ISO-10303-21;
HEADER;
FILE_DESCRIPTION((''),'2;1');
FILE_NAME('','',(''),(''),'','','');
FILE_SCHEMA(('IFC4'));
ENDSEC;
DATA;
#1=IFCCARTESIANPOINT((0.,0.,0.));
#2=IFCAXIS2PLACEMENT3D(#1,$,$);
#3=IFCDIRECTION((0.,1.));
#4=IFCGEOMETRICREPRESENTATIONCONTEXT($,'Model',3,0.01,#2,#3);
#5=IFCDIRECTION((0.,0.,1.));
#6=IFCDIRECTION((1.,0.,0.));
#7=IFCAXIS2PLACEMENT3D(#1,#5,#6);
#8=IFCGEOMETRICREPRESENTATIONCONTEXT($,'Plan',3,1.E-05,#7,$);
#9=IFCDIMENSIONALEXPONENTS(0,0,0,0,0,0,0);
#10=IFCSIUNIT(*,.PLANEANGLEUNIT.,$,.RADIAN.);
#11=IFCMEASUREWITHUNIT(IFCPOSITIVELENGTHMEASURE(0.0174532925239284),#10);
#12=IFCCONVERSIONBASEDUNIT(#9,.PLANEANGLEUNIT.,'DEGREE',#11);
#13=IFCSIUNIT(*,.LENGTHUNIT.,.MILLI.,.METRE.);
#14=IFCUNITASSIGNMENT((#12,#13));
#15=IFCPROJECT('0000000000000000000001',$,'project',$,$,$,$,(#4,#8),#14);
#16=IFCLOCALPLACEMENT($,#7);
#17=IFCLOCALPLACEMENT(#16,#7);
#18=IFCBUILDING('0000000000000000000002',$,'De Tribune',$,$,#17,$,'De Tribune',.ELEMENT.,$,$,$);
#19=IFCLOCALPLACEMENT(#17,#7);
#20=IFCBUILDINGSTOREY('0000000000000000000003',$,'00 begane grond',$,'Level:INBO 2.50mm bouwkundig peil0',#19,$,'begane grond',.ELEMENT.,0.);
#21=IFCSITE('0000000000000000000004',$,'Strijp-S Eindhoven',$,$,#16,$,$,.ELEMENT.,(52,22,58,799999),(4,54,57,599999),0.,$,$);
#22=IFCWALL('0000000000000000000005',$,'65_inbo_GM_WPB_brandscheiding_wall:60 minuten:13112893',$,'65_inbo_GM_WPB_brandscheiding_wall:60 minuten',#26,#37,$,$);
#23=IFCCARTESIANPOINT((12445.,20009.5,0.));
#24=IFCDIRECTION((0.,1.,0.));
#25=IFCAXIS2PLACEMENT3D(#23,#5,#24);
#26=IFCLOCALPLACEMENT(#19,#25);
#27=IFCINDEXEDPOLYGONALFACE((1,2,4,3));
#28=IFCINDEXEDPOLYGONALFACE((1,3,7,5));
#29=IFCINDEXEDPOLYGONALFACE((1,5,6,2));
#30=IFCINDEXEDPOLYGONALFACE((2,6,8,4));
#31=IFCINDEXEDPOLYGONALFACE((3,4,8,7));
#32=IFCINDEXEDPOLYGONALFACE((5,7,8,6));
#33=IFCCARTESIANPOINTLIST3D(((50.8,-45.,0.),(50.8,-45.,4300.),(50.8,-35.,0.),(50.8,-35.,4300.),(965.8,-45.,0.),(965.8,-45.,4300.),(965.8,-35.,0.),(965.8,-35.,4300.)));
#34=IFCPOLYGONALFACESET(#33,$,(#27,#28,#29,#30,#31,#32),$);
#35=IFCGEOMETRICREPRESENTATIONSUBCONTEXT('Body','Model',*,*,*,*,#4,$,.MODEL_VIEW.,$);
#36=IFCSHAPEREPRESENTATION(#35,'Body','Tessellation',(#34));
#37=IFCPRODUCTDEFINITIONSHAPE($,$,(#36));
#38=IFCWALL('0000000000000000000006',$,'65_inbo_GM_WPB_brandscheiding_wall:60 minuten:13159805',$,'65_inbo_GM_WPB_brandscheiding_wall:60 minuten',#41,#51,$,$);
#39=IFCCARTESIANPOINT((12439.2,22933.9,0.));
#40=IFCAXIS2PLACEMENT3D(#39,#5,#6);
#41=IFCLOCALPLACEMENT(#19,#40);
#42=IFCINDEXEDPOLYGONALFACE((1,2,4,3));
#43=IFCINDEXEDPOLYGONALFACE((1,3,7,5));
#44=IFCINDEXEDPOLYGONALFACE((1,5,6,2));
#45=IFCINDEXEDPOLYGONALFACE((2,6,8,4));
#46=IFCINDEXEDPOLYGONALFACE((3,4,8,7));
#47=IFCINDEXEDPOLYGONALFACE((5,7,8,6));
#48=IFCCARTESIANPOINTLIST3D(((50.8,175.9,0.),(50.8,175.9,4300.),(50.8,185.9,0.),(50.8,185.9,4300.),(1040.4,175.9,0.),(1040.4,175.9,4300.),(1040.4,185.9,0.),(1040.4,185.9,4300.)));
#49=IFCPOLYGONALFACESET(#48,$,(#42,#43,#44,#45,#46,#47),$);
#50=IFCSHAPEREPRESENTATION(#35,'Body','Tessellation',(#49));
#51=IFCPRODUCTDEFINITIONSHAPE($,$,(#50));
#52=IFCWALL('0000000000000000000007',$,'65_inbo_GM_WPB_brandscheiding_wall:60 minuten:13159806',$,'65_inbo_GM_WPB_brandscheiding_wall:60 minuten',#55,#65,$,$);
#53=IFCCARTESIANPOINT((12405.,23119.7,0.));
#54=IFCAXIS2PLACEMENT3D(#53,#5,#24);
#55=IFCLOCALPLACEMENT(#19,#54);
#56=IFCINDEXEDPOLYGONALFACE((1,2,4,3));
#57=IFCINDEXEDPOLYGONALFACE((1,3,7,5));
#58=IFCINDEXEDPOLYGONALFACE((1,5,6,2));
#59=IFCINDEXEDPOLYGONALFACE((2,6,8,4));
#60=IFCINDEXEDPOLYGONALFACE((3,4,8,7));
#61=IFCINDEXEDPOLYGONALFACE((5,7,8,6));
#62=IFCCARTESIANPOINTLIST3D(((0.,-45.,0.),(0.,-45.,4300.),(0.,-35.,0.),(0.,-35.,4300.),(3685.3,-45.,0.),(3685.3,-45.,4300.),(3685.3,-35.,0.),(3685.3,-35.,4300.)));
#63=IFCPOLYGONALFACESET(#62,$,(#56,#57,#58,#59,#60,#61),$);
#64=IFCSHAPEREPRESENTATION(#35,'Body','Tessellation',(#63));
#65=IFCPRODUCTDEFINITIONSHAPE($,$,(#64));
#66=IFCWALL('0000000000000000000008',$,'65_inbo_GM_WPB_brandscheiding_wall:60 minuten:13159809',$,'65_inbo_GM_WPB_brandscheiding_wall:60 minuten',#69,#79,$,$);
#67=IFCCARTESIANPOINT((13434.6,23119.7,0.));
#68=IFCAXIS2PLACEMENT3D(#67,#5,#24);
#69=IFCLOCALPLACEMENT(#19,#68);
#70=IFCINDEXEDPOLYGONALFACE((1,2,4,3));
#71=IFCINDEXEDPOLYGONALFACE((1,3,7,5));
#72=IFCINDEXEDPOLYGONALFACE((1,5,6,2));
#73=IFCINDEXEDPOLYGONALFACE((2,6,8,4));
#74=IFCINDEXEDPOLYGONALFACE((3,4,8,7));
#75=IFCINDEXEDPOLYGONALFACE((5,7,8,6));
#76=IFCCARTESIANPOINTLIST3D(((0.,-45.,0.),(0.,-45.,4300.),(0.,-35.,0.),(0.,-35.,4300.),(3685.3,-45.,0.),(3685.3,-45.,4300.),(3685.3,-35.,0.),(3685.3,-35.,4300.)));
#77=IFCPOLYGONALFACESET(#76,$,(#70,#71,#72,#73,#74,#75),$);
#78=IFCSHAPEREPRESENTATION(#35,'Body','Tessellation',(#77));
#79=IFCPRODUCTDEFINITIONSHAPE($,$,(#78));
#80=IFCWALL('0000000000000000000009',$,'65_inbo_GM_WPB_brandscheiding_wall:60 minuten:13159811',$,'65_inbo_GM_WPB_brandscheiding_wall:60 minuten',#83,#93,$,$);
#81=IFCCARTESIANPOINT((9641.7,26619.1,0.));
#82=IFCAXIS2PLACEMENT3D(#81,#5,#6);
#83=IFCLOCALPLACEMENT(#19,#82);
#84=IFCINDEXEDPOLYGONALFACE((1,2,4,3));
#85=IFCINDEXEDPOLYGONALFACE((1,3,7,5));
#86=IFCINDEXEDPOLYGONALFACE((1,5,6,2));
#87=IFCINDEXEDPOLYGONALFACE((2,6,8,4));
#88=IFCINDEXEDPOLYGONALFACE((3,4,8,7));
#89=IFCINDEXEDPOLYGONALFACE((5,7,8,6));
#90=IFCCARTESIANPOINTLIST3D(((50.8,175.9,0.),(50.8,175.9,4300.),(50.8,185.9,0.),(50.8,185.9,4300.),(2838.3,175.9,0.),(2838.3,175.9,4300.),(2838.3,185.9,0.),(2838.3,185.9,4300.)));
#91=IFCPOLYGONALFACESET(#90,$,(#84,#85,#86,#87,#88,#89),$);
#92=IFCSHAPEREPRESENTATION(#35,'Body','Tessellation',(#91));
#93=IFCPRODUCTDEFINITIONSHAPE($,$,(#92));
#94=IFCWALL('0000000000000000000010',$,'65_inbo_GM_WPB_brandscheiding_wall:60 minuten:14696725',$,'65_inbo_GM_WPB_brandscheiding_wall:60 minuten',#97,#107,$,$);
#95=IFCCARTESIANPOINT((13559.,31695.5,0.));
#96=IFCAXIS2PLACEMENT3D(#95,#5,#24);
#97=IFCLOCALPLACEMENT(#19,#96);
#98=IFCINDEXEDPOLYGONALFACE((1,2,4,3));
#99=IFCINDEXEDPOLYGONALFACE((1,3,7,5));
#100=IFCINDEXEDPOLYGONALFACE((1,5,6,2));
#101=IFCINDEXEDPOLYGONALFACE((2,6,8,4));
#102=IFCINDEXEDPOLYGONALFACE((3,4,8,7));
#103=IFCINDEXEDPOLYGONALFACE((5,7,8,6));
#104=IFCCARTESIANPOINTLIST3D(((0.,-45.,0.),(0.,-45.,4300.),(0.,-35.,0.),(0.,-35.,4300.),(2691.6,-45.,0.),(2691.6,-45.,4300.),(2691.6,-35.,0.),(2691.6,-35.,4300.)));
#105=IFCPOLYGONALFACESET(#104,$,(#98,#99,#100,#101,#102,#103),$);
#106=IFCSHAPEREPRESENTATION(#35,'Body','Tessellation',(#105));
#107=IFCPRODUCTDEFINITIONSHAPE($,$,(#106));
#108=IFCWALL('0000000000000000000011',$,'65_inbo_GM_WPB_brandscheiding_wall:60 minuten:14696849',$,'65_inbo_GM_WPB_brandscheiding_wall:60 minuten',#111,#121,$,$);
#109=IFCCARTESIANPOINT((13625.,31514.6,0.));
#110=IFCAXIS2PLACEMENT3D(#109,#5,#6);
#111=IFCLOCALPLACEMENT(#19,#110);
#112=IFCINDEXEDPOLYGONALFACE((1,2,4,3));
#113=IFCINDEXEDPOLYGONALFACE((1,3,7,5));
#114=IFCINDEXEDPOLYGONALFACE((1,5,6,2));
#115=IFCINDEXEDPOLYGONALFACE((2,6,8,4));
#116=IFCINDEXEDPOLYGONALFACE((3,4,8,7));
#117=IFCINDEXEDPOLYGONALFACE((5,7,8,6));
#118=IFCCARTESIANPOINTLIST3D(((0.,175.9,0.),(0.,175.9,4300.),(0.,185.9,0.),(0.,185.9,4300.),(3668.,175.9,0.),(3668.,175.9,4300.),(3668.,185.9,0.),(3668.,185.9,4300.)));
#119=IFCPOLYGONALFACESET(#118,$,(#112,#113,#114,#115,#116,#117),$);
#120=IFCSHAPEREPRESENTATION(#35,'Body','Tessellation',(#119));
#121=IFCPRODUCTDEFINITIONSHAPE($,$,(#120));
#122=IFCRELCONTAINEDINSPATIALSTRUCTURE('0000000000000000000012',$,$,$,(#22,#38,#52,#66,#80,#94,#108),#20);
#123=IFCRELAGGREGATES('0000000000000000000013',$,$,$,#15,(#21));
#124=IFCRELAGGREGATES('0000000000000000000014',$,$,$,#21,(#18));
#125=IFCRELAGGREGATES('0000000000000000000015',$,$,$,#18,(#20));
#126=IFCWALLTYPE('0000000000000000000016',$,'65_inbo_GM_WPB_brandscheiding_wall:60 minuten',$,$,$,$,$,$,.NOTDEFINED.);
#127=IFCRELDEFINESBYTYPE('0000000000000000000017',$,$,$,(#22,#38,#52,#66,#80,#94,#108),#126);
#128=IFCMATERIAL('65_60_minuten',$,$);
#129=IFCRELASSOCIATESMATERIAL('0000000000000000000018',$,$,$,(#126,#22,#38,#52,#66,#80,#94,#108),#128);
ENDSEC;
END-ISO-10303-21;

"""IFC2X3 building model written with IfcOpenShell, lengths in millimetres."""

from ifc_helpers import new_model, entity, si_unit, converted_unit, direction, frame, frame_2d, origin, origin_with_axes, origin_2d_with_axis, place, context, subcontext, project, spatial, rectangle, extrude, material, type_object, element, save


model = new_model("IFC2X3")

# Units and contexts
model_context = context("Model", 3, precision=0.01, world=origin(), true_north=direction((0.0, 1.0)))
plan_context = context("Plan", 3, precision=1e-05, world=origin_with_axes())
body_context = subcontext(model_context, "Body", "Model", "MODEL_VIEW")
ifc_project = project(units=[converted_unit("PLANEANGLEUNIT", "DEGREE", entity("IfcPositiveLengthMeasure", 0.0174532925239284), si_unit("PLANEANGLEUNIT", "RADIAN"), dimensions=[0, 0, 0, 0, 0, 0, 0]), si_unit("LENGTHUNIT", "METRE", prefix="MILLI")], contexts=[model_context, plan_context])

# Site, building, storey
site_placement = place(None, origin_with_axes())
site = spatial("IfcSite", under=ifc_project, at=site_placement, Name="Strijp-S Eindhoven", CompositionType="ELEMENT", RefLatitude=(52, 22, 58, 799999), RefLongitude=(4, 54, 57, 599999), RefElevation=0.0)
building_placement = place(site_placement, origin_with_axes())
building = spatial("IfcBuilding", under=site, at=building_placement, Name="De Tribune", LongName="De Tribune", CompositionType="ELEMENT")
storey_placement = place(building_placement, origin_with_axes())
storey = spatial("IfcBuildingStorey", under=building, at=storey_placement, Name="00 begane grond", ObjectType="Level:INBO 2.50mm bouwkundig peil0", LongName="begane grond", CompositionType="ELEMENT", Elevation=0.0)

# Shared definitions
ifc_material_1 = material(Name="65_60_minuten")

# Walls
wall_type_1 = type_object("IfcWallType", Name="65_inbo_GM_WPB_brandscheiding_wall:60 minuten", PredefinedType="NOTDEFINED", material=ifc_material_1)
wall_1_placement = place(storey_placement, frame((12445.0, 20009.5, 0.0), z_axis=(0.0, 0.0, 1.0), x_axis=(0.0, 1.0, 0.0)))
element("IfcWall", 1, at=wall_1_placement, inside=storey, type_object=wall_type_1, material=ifc_material_1, Name="65_inbo_GM_WPB_brandscheiding_wall:60 minuten:13112893", ObjectType="65_inbo_GM_WPB_brandscheiding_wall:60 minuten", context=body_context, shape_type="SweptSolid", body=[
    extrude(rectangle(XDim=915.0, YDim=10.0, at=frame_2d((0.0, 0.0), x_axis=(1.0, 0.0))), frame((508.3, -40.0, 0.0), z_axis=(0.0, 0.0, 1.0), x_axis=(-1.0, 0.0, 0.0)), (0.0, 0.0, 1.0), 4300.0),
])
wall_2_placement = place(storey_placement, frame((12439.2, 22933.9, 0.0), z_axis=(0.0, 0.0, 1.0), x_axis=(1.0, 0.0, 0.0)))
element("IfcWall", 2, at=wall_2_placement, inside=storey, type_object=wall_type_1, material=ifc_material_1, Name="65_inbo_GM_WPB_brandscheiding_wall:60 minuten:13159805", ObjectType="65_inbo_GM_WPB_brandscheiding_wall:60 minuten", context=body_context, shape_type="SweptSolid", body=[
    extrude(rectangle(XDim=989.6, YDim=10.0, at=frame_2d((0.0, 0.0), x_axis=(1.0, 0.0))), frame((545.6, 180.9, 0.0), z_axis=(0.0, 0.0, 1.0), x_axis=(-1.0, 0.0, 0.0)), (0.0, 0.0, 1.0), 4300.0),
])
for number, where, z_axis, x_axis, name in (
    (3, (12405.0, 23119.7, 0.0), (0.0, 0.0, 1.0), (0.0, 1.0, 0.0), "65_inbo_GM_WPB_brandscheiding_wall:60 minuten:13159806"),
    (4, (13434.6, 23119.7, 0.0), (0.0, 0.0, 1.0), (0.0, 1.0, 0.0), "65_inbo_GM_WPB_brandscheiding_wall:60 minuten:13159809"),
):
    element("IfcWall", number, at=place(storey_placement, frame(where, z_axis=z_axis, x_axis=x_axis)), inside=storey, type_object=wall_type_1, material=ifc_material_1, Name=name, ObjectType="65_inbo_GM_WPB_brandscheiding_wall:60 minuten", context=body_context, shape_type="SweptSolid", body=[
        extrude(rectangle(XDim=10.0, YDim=3685.3, at=origin_2d_with_axis()), frame((1842.7, -40.0, 0.0), z_axis=(0.0, 0.0, 1.0), x_axis=(0.0, -1.0, 0.0)), (0.0, 0.0, 1.0), 4300.0),
    ])
wall_3_placement = place(storey_placement, frame((9641.7, 26619.1, 0.0), z_axis=(0.0, 0.0, 1.0), x_axis=(1.0, 0.0, 0.0)))
element("IfcWall", 5, at=wall_3_placement, inside=storey, type_object=wall_type_1, material=ifc_material_1, Name="65_inbo_GM_WPB_brandscheiding_wall:60 minuten:13159811", ObjectType="65_inbo_GM_WPB_brandscheiding_wall:60 minuten", context=body_context, shape_type="SweptSolid", body=[
    extrude(rectangle(XDim=2787.5, YDim=10.0, at=frame_2d((0.0, 0.0), x_axis=(1.0, 0.0))), frame((1444.6, 180.9, 0.0), z_axis=(0.0, 0.0, 1.0), x_axis=(-1.0, 0.0, 0.0)), (0.0, 0.0, 1.0), 4300.0),
])
wall_4_placement = place(storey_placement, frame((13559.0, 31695.5, 0.0), z_axis=(0.0, 0.0, 1.0), x_axis=(0.0, 1.0, 0.0)))
element("IfcWall", 6, at=wall_4_placement, inside=storey, type_object=wall_type_1, material=ifc_material_1, Name="65_inbo_GM_WPB_brandscheiding_wall:60 minuten:14696725", ObjectType="65_inbo_GM_WPB_brandscheiding_wall:60 minuten", context=body_context, shape_type="SweptSolid", body=[
    extrude(rectangle(XDim=10.0, YDim=2691.6, at=origin_2d_with_axis()), frame((1345.8, -40.0, 0.0), z_axis=(0.0, 0.0, 1.0), x_axis=(0.0, -1.0, 0.0)), (0.0, 0.0, 1.0), 4300.0),
])
wall_5_placement = place(storey_placement, frame((13625.0, 31514.6, 0.0), z_axis=(0.0, 0.0, 1.0), x_axis=(1.0, 0.0, 0.0)))
element("IfcWall", 7, at=wall_5_placement, inside=storey, type_object=wall_type_1, material=ifc_material_1, Name="65_inbo_GM_WPB_brandscheiding_wall:60 minuten:14696849", ObjectType="65_inbo_GM_WPB_brandscheiding_wall:60 minuten", context=body_context, shape_type="SweptSolid", body=[
    extrude(rectangle(XDim=10.0, YDim=3668.0, at=frame_2d((0.0, 0.0), x_axis=(1.0, 0.0))), frame((1834.0, 180.9, 0.0), z_axis=(0.0, 0.0, 1.0), x_axis=(0.0, -1.0, 0.0)), (0.0, 0.0, 1.0), 4300.0),
])

save(model, "model.ifc")
